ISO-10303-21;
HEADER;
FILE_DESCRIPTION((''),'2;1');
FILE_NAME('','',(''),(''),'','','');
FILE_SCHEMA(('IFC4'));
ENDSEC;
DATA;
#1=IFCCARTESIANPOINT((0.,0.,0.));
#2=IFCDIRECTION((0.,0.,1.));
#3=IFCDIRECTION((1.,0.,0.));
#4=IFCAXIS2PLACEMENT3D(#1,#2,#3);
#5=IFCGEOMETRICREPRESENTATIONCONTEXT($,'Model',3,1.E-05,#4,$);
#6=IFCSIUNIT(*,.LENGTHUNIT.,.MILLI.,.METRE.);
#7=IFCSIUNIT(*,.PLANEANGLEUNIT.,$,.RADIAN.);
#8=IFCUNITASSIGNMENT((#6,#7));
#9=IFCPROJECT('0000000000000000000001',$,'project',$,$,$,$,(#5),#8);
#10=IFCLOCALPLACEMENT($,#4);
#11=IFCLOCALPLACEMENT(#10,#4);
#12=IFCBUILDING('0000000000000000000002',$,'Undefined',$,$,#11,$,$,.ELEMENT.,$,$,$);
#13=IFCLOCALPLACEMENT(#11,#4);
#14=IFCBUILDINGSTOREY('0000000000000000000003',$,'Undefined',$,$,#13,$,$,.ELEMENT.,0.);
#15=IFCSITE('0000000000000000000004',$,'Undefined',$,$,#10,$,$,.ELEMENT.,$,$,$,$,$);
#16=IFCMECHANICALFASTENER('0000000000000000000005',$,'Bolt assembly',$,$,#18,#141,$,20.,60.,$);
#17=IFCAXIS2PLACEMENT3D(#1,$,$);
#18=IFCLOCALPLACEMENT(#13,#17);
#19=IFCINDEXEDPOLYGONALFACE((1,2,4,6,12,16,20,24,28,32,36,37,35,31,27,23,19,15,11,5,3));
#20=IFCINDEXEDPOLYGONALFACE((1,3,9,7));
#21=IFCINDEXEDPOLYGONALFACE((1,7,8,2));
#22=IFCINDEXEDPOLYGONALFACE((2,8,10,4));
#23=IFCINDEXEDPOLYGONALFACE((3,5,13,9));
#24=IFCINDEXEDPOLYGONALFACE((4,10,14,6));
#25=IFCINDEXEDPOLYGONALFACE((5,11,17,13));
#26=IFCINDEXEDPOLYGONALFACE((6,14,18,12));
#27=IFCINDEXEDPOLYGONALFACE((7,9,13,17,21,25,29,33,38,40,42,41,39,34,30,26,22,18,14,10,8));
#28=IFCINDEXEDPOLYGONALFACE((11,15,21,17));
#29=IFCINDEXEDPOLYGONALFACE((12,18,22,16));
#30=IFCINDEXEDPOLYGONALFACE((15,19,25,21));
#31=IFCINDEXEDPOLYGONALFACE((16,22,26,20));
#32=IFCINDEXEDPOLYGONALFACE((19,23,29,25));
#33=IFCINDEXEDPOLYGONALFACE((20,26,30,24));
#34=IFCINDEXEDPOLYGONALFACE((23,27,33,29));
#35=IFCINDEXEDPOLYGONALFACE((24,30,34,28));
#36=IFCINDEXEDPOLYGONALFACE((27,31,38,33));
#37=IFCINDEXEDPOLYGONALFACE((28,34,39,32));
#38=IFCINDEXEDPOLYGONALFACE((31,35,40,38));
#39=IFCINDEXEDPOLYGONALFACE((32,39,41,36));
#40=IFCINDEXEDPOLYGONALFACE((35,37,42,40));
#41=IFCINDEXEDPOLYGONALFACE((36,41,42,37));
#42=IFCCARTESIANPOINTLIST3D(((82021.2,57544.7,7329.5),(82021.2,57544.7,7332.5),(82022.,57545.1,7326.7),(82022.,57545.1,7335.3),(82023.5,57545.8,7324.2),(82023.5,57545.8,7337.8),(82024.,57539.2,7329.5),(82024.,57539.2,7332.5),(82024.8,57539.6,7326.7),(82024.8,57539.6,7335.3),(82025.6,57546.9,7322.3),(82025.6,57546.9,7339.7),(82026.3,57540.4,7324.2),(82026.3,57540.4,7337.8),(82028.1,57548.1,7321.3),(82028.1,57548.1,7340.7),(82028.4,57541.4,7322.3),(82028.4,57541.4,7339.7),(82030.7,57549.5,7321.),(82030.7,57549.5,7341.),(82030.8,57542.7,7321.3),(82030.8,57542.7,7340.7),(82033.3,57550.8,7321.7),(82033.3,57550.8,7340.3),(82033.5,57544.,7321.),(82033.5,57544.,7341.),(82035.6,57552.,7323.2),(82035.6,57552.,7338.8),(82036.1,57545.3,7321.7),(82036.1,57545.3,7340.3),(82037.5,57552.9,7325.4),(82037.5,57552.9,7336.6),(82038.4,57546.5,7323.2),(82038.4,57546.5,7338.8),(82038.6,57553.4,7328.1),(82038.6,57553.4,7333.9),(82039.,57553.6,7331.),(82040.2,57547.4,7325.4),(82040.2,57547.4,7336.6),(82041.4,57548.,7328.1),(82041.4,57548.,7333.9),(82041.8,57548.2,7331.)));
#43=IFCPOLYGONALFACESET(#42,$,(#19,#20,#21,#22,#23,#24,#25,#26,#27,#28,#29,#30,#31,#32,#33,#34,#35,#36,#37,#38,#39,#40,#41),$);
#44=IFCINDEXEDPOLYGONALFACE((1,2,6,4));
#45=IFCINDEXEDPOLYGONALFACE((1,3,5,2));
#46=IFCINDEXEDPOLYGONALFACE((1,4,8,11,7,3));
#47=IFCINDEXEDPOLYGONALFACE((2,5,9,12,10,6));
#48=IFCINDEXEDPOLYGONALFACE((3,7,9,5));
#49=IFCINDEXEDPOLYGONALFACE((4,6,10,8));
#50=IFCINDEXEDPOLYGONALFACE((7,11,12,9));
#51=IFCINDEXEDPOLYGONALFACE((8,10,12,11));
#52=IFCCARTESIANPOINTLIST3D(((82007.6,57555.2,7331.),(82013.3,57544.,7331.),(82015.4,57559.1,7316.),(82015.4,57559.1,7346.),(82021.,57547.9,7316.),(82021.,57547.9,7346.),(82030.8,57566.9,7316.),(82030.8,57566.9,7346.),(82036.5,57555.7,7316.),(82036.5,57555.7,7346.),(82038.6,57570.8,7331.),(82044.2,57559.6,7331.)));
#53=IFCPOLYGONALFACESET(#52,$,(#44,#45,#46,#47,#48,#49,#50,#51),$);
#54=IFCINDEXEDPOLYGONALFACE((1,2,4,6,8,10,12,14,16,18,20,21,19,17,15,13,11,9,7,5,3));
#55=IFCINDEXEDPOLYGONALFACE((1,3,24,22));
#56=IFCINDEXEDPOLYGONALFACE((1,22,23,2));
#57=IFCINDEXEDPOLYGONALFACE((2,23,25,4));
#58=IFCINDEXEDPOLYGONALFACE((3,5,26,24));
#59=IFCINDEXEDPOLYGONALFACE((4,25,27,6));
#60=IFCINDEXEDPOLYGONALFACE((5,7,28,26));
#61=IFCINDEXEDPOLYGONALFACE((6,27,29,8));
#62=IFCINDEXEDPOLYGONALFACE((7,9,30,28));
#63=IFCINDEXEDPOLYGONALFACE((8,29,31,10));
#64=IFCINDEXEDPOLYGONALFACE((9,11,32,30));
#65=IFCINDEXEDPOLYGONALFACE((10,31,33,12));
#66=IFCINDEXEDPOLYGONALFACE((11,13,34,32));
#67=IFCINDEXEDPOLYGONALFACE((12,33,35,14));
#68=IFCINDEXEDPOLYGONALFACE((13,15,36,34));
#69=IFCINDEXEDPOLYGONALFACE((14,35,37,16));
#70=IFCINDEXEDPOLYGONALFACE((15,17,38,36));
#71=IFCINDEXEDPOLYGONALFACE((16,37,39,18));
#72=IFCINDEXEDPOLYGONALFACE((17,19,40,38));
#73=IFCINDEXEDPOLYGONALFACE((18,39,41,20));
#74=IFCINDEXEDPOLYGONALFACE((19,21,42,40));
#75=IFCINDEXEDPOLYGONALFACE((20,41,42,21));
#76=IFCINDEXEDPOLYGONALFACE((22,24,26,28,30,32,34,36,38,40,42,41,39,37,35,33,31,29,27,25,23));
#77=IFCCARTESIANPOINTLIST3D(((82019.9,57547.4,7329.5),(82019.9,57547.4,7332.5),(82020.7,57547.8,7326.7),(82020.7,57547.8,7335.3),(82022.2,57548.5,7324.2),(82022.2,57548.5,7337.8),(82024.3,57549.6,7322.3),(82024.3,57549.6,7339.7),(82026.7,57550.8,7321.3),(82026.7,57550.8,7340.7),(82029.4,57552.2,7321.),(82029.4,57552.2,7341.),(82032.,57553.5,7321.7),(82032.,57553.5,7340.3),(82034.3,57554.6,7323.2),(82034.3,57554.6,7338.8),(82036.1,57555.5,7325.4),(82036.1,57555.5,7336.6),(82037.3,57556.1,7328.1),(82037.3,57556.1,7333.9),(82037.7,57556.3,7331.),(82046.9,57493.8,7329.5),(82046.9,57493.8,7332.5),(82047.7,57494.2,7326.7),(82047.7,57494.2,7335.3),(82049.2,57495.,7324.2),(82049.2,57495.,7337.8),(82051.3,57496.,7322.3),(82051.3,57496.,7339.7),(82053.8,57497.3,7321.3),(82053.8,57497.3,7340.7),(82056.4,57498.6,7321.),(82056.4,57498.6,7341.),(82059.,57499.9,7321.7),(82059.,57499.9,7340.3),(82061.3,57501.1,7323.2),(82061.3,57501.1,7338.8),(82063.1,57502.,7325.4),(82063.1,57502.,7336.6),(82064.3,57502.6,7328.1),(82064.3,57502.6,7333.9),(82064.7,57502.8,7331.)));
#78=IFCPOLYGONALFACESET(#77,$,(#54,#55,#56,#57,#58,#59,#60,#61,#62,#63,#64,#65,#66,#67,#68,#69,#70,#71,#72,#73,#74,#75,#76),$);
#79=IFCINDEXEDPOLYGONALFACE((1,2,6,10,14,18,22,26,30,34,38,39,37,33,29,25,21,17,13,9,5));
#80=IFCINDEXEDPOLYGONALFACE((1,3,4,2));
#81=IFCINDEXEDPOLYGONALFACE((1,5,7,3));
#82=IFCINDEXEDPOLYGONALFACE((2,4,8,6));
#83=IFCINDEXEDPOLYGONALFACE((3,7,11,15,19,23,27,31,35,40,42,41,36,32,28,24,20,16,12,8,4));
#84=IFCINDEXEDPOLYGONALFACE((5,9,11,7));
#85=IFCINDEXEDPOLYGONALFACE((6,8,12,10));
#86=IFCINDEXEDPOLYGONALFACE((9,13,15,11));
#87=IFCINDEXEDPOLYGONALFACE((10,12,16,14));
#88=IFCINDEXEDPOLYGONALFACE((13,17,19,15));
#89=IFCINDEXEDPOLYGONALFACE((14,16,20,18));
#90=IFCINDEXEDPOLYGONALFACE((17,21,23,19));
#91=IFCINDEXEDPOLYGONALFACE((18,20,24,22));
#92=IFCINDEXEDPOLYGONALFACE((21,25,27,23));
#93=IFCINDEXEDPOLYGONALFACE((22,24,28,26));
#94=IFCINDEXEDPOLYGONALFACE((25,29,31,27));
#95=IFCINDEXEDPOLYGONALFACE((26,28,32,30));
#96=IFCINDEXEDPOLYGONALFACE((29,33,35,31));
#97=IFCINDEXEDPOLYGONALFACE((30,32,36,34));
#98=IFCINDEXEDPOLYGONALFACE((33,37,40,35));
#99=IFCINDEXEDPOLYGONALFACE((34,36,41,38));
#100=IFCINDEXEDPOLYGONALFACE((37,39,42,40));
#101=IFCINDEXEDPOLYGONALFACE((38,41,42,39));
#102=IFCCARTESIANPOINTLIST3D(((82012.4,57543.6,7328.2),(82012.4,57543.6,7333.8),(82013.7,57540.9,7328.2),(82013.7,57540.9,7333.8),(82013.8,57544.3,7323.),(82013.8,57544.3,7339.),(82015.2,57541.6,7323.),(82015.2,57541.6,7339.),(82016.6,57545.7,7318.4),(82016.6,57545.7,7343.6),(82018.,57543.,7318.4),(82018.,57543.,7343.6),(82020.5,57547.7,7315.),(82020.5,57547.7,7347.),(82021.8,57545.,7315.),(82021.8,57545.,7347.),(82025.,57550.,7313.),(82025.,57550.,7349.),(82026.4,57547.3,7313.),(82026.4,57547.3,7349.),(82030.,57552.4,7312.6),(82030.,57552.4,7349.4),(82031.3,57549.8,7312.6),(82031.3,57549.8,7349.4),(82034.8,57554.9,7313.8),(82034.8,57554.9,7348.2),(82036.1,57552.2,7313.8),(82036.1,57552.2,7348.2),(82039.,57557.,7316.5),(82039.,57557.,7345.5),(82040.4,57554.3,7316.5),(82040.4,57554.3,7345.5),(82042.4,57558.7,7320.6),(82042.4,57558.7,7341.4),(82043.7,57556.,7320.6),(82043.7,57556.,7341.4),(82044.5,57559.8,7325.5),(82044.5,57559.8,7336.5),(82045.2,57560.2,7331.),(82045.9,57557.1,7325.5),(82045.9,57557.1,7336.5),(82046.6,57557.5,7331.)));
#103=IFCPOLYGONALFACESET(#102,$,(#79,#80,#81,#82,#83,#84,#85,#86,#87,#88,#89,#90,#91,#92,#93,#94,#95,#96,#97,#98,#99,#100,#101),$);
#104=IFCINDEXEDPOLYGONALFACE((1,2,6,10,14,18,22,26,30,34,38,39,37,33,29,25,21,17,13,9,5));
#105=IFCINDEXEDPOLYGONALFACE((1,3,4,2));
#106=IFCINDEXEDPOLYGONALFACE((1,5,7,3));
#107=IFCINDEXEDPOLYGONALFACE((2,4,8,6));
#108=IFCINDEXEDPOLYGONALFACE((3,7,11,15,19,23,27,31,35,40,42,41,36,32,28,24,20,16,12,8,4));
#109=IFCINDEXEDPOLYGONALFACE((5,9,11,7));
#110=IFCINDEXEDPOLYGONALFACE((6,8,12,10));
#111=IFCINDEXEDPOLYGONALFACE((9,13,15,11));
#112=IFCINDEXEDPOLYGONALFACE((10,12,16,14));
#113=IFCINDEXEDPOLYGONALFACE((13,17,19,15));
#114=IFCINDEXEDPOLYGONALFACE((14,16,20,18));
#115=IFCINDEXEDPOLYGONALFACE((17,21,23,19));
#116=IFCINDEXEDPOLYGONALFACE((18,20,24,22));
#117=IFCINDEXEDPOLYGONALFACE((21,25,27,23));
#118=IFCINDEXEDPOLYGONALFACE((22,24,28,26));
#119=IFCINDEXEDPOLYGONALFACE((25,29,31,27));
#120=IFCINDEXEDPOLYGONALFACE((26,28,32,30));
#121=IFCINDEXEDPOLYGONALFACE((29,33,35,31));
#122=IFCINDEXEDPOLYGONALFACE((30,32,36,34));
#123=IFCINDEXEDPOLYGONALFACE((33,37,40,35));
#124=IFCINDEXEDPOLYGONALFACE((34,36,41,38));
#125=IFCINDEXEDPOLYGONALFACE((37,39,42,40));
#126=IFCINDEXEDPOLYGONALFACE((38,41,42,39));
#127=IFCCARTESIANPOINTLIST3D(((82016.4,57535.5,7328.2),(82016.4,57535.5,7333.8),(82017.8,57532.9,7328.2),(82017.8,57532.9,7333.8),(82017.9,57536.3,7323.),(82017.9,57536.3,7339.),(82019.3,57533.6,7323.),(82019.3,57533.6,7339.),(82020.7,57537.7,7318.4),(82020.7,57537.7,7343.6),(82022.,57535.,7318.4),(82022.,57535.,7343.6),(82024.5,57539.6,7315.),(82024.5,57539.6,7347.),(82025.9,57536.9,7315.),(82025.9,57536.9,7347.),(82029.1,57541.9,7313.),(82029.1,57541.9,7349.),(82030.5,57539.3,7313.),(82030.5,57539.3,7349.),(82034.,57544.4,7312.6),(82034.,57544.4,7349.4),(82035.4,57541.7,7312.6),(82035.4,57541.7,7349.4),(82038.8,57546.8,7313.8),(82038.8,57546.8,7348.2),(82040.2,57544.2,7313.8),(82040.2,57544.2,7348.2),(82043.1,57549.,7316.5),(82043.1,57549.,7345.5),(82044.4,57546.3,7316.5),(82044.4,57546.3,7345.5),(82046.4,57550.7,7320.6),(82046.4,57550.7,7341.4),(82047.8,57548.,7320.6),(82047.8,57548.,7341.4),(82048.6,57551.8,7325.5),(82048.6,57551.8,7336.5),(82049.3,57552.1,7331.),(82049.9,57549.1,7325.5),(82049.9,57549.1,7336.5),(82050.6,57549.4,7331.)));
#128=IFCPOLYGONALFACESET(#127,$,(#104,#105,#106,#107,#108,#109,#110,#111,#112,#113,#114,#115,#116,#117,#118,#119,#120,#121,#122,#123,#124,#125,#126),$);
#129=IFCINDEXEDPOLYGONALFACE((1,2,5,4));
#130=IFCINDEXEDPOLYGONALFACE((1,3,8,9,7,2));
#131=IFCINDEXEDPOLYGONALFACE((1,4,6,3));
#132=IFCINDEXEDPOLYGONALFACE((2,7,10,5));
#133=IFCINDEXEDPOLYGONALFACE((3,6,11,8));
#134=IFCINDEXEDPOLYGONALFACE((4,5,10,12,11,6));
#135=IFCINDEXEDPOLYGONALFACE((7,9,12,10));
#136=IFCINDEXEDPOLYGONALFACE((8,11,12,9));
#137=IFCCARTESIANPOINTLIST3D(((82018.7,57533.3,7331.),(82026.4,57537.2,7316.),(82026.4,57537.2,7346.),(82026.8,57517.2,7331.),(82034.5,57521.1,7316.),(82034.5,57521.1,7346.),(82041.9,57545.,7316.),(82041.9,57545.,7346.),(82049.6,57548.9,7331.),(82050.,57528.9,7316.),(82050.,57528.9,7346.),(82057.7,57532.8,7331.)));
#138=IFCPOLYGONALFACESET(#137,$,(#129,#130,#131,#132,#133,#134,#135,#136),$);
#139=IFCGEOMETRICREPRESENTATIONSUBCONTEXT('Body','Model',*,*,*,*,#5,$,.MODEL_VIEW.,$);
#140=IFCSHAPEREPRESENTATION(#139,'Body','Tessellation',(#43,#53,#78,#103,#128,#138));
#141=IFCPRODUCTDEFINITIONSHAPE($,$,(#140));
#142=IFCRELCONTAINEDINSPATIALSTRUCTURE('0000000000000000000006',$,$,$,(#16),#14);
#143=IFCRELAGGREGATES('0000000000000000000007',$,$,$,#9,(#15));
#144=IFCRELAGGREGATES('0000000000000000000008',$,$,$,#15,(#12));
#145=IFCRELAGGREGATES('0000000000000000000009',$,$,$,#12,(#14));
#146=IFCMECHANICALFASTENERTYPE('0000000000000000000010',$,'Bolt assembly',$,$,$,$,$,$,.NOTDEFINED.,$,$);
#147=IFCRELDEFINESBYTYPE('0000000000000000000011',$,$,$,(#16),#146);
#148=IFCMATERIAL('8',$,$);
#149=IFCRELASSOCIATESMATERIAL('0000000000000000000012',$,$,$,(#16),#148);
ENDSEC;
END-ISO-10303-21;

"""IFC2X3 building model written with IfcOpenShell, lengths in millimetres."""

from ifc_helpers import new_model, si_unit, frame, origin_with_axes, origin_2d_with_axis, place, context, subcontext, project, spatial, polyline, circle, outline, extrude, source, transform, mapped, material, type_object, element, save


model = new_model("IFC2X3")

# Units and contexts
model_context = context("Model", 3, precision=1e-05, world=origin_with_axes())
body_context = subcontext(model_context, "Body", "Model", "MODEL_VIEW")
ifc_project = project(units=[si_unit("LENGTHUNIT", "METRE", prefix="MILLI"), si_unit("PLANEANGLEUNIT", "RADIAN")], contexts=[model_context])

# Site, building, storey
site_placement = place(None, origin_with_axes())
site = spatial("IfcSite", under=ifc_project, at=site_placement, Name="Undefined", CompositionType="ELEMENT")
building_placement = place(site_placement, origin_with_axes())
building = spatial("IfcBuilding", under=site, at=building_placement, Name="Undefined", CompositionType="ELEMENT")
storey_placement = place(building_placement, origin_with_axes())
storey = spatial("IfcBuildingStorey", under=building, at=storey_placement, Name="Undefined", CompositionType="ELEMENT", Elevation=0.0)

# Mechanical fastener
ifc_material_1 = material(Name="8")
mechanical_fastener_type = type_object("IfcMechanicalFastenerType", Name="Bolt assembly")
shared_shape_1 = source(origin_with_axes(), body_context, "Body", "SweptSolid", [
    extrude(circle(Radius=10.0, at=origin_2d_with_axis()), frame((0.0, 0.0, 0.0), z_axis=(0.0, 1.0, 0.0), x_axis=(1.0, 0.0, 0.0)), (0.0, 0.0, 1.0), 6.1),
    extrude(outline(polyline([(17.3, 0.0), (8.7, 15.0), (-8.7, 15.0), (-17.3, 0.0), (-8.7, -15.0), (8.7, -15.0), (17.3, 0.0)])), frame((0.0, -15.5, 0.0), z_axis=(0.0, 1.0, 0.0), x_axis=(1.0, 0.0, 0.0)), (0.0, 0.0, 1.0), 12.5),
    extrude(circle(Radius=10.0, at=origin_2d_with_axis()), frame((0.0, -3.0, 0.0), z_axis=(0.0, 1.0, 0.0), x_axis=(1.0, 0.0, 0.0)), (0.0, 0.0, 1.0), 60.0),
    extrude(circle(Radius=18.5, at=origin_2d_with_axis()), frame((0.0, -3.0, 0.0), z_axis=(0.0, 1.0, 0.0), x_axis=(1.0, 0.0, 0.0)), (0.0, 0.0, 1.0), 3.0),
    extrude(circle(Radius=18.5, at=origin_2d_with_axis()), frame((0.0, 6.0, 0.0), z_axis=(0.0, 1.0, 0.0), x_axis=(1.0, 0.0, 0.0)), (0.0, 0.0, 1.0), 3.0),
    extrude(outline(polyline([(17.3, 0.0), (8.7, 15.0), (-8.7, 15.0), (-17.3, 0.0), (-8.7, -15.0), (8.7, -15.0), (17.3, 0.0)])), frame((0.0, 9.0, 0.0), z_axis=(0.0, 1.0, 0.0), x_axis=(1.0, 0.0, 0.0)), (0.0, 0.0, 1.0), 18.0),
])
mechanical_fastener_1_placement = place(storey_placement, frame((82030.1, 57549.1, 7331.0), z_axis=(0.0, 0.0, -1.0), x_axis=(0.89277, 0.450512, 0.0)))
element("IfcMechanicalFastener", 1, at=mechanical_fastener_1_placement, inside=storey, type_object=mechanical_fastener_type, material=ifc_material_1, Name="Bolt assembly", NominalDiameter=20.0, NominalLength=60.0, context=body_context, shape_type="MappedRepresentation", body=[
    mapped(shared_shape_1, transform((0.0, 0.0, 0.0))),
])

save(model, "model.ifc")
